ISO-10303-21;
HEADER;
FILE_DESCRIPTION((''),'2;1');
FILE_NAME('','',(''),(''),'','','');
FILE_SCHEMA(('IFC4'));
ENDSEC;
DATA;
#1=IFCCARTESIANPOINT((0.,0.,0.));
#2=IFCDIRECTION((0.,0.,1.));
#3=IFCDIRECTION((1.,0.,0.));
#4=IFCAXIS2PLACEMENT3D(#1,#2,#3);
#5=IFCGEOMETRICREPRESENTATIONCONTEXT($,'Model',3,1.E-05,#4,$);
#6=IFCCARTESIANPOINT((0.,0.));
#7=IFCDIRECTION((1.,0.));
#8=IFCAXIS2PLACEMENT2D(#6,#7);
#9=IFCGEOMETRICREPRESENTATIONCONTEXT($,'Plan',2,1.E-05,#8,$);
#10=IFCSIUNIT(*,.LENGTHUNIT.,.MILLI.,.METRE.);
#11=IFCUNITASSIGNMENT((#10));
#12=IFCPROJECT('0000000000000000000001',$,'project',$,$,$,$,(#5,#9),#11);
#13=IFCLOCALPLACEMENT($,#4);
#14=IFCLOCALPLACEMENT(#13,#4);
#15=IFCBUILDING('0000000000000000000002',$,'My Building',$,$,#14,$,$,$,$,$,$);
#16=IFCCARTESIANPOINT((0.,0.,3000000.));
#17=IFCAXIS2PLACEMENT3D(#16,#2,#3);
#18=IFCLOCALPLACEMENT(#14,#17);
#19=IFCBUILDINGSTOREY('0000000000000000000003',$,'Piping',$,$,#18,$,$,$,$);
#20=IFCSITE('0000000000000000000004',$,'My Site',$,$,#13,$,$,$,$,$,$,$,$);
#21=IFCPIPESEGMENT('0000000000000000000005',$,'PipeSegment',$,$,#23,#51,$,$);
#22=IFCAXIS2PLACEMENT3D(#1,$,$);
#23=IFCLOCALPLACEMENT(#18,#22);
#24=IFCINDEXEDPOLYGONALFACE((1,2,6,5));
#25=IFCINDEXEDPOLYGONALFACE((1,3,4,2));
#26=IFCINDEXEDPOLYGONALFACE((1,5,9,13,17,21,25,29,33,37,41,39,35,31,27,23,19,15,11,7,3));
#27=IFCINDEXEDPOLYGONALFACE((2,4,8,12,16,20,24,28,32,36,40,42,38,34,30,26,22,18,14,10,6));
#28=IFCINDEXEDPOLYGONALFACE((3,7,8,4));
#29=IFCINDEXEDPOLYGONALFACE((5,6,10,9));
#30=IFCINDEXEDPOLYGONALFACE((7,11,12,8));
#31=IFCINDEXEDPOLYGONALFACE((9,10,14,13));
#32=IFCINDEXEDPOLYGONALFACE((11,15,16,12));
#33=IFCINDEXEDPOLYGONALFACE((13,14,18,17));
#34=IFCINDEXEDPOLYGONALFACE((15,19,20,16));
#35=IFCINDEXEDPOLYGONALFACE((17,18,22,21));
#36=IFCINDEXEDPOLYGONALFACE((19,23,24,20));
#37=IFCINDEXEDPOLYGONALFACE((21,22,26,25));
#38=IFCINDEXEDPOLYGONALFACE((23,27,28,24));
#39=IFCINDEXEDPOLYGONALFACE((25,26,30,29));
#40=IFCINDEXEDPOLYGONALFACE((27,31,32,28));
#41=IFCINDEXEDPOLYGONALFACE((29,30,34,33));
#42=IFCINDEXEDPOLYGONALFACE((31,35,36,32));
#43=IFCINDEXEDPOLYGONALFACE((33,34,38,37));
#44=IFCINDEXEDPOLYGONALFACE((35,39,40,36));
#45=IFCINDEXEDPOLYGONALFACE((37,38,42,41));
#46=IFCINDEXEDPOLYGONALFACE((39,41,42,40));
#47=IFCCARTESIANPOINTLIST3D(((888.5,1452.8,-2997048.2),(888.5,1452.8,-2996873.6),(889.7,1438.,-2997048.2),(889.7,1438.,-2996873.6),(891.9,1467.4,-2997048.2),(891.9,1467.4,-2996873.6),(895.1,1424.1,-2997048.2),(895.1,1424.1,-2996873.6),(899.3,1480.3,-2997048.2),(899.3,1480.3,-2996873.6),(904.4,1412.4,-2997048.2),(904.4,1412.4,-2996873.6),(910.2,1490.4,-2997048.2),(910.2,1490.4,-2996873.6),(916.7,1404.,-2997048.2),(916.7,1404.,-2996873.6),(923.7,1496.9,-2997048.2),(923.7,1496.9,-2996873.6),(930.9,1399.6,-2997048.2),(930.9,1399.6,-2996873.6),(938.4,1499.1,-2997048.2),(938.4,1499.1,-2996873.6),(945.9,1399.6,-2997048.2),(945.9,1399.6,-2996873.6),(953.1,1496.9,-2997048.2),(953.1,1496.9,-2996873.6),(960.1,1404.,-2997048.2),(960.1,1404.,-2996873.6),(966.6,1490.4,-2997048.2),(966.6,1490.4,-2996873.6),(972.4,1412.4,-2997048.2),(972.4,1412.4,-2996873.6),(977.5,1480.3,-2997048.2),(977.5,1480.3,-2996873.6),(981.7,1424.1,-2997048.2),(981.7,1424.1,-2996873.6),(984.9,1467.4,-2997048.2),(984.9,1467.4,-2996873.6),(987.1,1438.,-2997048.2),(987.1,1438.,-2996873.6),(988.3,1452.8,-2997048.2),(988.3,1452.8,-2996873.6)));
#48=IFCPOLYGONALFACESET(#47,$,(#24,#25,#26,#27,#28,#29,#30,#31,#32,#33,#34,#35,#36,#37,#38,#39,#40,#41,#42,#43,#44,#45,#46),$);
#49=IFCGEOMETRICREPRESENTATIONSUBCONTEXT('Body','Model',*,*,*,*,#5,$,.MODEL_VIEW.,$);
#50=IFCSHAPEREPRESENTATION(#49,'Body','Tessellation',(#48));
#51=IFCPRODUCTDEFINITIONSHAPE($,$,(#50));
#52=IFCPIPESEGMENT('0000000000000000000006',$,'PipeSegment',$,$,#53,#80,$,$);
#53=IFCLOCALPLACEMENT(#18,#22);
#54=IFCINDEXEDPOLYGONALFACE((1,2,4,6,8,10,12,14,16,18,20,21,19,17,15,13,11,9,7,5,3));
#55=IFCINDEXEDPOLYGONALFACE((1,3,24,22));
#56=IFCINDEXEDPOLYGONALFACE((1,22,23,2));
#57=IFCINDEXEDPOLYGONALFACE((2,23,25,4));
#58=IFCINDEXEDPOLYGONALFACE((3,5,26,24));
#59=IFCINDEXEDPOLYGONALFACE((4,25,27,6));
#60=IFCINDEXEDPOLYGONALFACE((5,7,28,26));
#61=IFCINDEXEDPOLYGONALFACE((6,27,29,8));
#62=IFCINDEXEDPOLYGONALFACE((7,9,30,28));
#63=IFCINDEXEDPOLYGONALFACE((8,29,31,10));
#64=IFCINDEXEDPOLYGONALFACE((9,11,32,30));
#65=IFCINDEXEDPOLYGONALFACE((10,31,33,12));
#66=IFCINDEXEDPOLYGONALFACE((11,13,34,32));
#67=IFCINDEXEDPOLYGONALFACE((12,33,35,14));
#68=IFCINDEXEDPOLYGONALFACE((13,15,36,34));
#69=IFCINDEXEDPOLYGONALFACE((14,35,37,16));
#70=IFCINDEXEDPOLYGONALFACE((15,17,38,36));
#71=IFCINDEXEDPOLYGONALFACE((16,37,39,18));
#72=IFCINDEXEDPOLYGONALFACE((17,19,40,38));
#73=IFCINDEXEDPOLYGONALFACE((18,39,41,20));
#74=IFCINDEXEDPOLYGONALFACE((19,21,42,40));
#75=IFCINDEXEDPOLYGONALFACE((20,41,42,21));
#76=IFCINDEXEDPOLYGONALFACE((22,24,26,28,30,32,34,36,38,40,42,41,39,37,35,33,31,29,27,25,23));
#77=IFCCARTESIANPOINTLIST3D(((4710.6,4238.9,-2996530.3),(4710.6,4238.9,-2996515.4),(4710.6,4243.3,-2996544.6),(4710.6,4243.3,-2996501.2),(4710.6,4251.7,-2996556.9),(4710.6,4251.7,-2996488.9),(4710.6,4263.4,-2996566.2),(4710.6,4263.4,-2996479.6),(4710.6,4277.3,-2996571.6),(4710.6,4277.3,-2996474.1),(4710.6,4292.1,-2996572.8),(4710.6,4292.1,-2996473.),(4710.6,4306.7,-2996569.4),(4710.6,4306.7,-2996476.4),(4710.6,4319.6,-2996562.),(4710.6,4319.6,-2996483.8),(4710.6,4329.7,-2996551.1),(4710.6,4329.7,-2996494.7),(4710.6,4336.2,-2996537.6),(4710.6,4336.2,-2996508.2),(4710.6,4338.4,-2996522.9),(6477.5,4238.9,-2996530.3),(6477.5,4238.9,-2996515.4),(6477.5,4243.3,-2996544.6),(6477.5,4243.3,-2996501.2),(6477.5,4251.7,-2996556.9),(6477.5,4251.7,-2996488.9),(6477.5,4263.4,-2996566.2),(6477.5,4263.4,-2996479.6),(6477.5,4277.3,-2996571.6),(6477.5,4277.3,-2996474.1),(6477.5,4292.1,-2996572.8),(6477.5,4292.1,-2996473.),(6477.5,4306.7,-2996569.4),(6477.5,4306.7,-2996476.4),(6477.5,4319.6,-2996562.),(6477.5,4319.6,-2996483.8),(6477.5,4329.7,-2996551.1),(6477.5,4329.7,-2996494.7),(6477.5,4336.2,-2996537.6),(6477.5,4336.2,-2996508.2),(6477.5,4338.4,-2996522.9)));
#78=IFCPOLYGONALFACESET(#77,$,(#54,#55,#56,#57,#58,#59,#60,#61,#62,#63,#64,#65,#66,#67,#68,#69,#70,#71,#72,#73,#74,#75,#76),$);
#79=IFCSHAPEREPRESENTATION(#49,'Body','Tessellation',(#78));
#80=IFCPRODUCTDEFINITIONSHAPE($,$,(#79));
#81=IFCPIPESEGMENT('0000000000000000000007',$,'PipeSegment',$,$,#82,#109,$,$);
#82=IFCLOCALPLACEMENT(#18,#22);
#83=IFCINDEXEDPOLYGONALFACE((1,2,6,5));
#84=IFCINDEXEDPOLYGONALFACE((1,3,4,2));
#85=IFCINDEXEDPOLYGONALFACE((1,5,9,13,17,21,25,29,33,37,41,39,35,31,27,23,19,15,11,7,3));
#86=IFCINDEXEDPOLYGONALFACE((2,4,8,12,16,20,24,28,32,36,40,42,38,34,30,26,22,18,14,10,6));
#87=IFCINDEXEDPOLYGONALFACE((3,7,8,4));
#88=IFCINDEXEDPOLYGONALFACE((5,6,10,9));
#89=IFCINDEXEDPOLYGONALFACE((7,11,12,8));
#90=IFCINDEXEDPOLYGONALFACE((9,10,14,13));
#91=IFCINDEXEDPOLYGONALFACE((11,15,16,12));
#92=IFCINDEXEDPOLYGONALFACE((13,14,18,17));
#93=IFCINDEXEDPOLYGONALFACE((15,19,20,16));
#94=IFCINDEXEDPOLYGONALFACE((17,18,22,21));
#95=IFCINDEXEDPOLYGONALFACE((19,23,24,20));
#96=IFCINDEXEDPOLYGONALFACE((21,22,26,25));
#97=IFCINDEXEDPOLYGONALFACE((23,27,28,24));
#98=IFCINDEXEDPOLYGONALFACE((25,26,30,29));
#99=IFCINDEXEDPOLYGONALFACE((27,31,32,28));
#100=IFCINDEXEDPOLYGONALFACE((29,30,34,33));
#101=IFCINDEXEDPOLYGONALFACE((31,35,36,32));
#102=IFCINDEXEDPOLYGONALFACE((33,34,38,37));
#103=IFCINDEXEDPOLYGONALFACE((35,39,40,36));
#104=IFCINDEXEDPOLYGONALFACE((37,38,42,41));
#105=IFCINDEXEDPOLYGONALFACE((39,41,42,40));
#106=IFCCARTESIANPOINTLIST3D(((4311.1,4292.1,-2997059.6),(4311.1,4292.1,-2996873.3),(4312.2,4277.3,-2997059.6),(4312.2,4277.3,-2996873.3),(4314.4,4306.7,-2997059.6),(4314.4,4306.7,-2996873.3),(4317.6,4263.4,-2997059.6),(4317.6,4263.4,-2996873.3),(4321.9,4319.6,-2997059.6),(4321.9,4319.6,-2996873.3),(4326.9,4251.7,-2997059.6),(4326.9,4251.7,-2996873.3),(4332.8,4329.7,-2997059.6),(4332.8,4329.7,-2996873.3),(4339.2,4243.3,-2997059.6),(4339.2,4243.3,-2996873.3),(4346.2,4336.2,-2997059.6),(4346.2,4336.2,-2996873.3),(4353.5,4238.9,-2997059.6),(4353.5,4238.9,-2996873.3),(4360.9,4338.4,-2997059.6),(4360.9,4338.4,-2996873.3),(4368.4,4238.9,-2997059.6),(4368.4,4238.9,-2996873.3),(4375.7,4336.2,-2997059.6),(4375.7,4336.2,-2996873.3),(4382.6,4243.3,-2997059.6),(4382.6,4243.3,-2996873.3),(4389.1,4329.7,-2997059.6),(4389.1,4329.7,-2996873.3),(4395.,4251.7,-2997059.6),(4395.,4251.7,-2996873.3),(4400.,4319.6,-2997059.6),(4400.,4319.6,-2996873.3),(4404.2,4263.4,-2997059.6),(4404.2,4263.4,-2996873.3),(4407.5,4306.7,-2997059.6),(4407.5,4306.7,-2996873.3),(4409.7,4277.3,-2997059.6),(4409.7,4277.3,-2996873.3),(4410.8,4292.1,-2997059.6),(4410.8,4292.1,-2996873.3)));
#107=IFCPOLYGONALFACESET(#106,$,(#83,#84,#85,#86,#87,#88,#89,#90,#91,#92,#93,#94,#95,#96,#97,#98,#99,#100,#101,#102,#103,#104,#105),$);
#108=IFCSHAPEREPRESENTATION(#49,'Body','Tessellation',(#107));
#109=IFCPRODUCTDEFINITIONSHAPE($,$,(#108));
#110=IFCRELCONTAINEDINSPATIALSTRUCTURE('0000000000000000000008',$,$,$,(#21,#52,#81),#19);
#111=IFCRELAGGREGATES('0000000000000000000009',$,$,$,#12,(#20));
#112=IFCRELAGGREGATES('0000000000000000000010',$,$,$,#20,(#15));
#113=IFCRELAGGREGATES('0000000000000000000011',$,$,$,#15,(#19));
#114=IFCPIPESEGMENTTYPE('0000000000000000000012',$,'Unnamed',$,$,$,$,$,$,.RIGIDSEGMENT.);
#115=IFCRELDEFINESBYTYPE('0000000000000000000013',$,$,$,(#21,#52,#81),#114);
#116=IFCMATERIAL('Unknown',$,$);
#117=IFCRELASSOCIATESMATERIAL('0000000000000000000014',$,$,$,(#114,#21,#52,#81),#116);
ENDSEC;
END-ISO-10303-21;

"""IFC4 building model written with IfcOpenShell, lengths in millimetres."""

from ifc_helpers import new_model, si_unit, frame, origin_with_axes, origin_2d_with_axis, place, context, subcontext, project, spatial, circle, extrude, material, material_profile, profile_set, profile_usage, type_object, element, save


model = new_model("IFC4")

# Units and contexts
model_context = context("Model", 3, precision=1e-05, world=origin_with_axes())
plan_context = context("Plan", 2, precision=1e-05, world=origin_2d_with_axis())
body_context = subcontext(model_context, "Body", "Model", "MODEL_VIEW")
ifc_project = project(units=[si_unit("LENGTHUNIT", "METRE", prefix="MILLI")], contexts=[model_context, plan_context])

# Site, building, storey
site_placement = place(None, origin_with_axes())
site = spatial("IfcSite", under=ifc_project, at=site_placement, Name="My Site")
building_placement = place(site_placement, origin_with_axes())
building = spatial("IfcBuilding", under=site, at=building_placement, Name="My Building")
storey_placement = place(building_placement, frame((0.0, 0.0, 3000000.0), z_axis=(0.0, 0.0, 1.0), x_axis=(1.0, 0.0, 0.0)))
storey = spatial("IfcBuildingStorey", under=building, at=storey_placement, Name="Piping")

# Pipe segments
ifc_material = material(Name="Unknown")
ifc_material_profile_1 = material_profile(ifc_material, circle(Radius=50.0))
ifc_profile_set_1 = profile_set([ifc_material_profile_1])
pipe_segment_type = type_object("IfcPipeSegmentType", Name="Unnamed", PredefinedType="RIGIDSEGMENT", material=ifc_profile_set_1)
ifc_profile_usage_1 = profile_usage(ifc_profile_set_1, cardinal=1)
pipe_segment_1_placement = place(storey_placement, frame((888.4, 1499.1, -2996873.6), z_axis=(0.0, 0.0, -1.0), x_axis=(0.0, 1.0, 0.0)))
element("IfcPipeSegment", 1, at=pipe_segment_1_placement, inside=storey, type_object=pipe_segment_type, material=ifc_profile_usage_1, Name="PipeSegment", context=body_context, shape_type="SweptSolid", body=[
    extrude(circle(Radius=50.0), frame((-50.0, 50.0, 0.0), z_axis=(0.0, 0.0, 1.0), x_axis=(1.0, 0.0, 0.0)), (0.0, 0.0, 1.0), 174.5),
])
ifc_profile_usage_2 = profile_usage(ifc_profile_set_1, cardinal=1)
pipe_segment_2_placement = place(storey_placement, frame((4710.6, 4338.4, -2996572.9), z_axis=(1.0, 0.0, 0.0), x_axis=(0.0, 1.0, 0.0)))
element("IfcPipeSegment", 2, at=pipe_segment_2_placement, inside=storey, type_object=pipe_segment_type, material=ifc_profile_usage_2, Name="PipeSegment", context=body_context, shape_type="SweptSolid", body=[
    extrude(circle(Radius=50.0), frame((-50.0, 50.0, 0.0), z_axis=(0.0, 0.0, 1.0), x_axis=(1.0, 0.0, 0.0)), (0.0, 0.0, 1.0), 1766.9),
])
ifc_profile_usage_3 = profile_usage(ifc_profile_set_1, cardinal=1)
pipe_segment_3_placement = place(storey_placement, frame((4410.9, 4338.4, -2997059.6), z_axis=(0.0, 0.0, 1.0), x_axis=(0.0, 1.0, 0.0)))
element("IfcPipeSegment", 3, at=pipe_segment_3_placement, inside=storey, type_object=pipe_segment_type, material=ifc_profile_usage_3, Name="PipeSegment", context=body_context, shape_type="SweptSolid", body=[
    extrude(circle(Radius=50.0), frame((-50.0, 50.0, 0.0), z_axis=(0.0, 0.0, 1.0), x_axis=(1.0, 0.0, 0.0)), (0.0, 0.0, 1.0), 186.4),
])

save(model, "model.ifc")
